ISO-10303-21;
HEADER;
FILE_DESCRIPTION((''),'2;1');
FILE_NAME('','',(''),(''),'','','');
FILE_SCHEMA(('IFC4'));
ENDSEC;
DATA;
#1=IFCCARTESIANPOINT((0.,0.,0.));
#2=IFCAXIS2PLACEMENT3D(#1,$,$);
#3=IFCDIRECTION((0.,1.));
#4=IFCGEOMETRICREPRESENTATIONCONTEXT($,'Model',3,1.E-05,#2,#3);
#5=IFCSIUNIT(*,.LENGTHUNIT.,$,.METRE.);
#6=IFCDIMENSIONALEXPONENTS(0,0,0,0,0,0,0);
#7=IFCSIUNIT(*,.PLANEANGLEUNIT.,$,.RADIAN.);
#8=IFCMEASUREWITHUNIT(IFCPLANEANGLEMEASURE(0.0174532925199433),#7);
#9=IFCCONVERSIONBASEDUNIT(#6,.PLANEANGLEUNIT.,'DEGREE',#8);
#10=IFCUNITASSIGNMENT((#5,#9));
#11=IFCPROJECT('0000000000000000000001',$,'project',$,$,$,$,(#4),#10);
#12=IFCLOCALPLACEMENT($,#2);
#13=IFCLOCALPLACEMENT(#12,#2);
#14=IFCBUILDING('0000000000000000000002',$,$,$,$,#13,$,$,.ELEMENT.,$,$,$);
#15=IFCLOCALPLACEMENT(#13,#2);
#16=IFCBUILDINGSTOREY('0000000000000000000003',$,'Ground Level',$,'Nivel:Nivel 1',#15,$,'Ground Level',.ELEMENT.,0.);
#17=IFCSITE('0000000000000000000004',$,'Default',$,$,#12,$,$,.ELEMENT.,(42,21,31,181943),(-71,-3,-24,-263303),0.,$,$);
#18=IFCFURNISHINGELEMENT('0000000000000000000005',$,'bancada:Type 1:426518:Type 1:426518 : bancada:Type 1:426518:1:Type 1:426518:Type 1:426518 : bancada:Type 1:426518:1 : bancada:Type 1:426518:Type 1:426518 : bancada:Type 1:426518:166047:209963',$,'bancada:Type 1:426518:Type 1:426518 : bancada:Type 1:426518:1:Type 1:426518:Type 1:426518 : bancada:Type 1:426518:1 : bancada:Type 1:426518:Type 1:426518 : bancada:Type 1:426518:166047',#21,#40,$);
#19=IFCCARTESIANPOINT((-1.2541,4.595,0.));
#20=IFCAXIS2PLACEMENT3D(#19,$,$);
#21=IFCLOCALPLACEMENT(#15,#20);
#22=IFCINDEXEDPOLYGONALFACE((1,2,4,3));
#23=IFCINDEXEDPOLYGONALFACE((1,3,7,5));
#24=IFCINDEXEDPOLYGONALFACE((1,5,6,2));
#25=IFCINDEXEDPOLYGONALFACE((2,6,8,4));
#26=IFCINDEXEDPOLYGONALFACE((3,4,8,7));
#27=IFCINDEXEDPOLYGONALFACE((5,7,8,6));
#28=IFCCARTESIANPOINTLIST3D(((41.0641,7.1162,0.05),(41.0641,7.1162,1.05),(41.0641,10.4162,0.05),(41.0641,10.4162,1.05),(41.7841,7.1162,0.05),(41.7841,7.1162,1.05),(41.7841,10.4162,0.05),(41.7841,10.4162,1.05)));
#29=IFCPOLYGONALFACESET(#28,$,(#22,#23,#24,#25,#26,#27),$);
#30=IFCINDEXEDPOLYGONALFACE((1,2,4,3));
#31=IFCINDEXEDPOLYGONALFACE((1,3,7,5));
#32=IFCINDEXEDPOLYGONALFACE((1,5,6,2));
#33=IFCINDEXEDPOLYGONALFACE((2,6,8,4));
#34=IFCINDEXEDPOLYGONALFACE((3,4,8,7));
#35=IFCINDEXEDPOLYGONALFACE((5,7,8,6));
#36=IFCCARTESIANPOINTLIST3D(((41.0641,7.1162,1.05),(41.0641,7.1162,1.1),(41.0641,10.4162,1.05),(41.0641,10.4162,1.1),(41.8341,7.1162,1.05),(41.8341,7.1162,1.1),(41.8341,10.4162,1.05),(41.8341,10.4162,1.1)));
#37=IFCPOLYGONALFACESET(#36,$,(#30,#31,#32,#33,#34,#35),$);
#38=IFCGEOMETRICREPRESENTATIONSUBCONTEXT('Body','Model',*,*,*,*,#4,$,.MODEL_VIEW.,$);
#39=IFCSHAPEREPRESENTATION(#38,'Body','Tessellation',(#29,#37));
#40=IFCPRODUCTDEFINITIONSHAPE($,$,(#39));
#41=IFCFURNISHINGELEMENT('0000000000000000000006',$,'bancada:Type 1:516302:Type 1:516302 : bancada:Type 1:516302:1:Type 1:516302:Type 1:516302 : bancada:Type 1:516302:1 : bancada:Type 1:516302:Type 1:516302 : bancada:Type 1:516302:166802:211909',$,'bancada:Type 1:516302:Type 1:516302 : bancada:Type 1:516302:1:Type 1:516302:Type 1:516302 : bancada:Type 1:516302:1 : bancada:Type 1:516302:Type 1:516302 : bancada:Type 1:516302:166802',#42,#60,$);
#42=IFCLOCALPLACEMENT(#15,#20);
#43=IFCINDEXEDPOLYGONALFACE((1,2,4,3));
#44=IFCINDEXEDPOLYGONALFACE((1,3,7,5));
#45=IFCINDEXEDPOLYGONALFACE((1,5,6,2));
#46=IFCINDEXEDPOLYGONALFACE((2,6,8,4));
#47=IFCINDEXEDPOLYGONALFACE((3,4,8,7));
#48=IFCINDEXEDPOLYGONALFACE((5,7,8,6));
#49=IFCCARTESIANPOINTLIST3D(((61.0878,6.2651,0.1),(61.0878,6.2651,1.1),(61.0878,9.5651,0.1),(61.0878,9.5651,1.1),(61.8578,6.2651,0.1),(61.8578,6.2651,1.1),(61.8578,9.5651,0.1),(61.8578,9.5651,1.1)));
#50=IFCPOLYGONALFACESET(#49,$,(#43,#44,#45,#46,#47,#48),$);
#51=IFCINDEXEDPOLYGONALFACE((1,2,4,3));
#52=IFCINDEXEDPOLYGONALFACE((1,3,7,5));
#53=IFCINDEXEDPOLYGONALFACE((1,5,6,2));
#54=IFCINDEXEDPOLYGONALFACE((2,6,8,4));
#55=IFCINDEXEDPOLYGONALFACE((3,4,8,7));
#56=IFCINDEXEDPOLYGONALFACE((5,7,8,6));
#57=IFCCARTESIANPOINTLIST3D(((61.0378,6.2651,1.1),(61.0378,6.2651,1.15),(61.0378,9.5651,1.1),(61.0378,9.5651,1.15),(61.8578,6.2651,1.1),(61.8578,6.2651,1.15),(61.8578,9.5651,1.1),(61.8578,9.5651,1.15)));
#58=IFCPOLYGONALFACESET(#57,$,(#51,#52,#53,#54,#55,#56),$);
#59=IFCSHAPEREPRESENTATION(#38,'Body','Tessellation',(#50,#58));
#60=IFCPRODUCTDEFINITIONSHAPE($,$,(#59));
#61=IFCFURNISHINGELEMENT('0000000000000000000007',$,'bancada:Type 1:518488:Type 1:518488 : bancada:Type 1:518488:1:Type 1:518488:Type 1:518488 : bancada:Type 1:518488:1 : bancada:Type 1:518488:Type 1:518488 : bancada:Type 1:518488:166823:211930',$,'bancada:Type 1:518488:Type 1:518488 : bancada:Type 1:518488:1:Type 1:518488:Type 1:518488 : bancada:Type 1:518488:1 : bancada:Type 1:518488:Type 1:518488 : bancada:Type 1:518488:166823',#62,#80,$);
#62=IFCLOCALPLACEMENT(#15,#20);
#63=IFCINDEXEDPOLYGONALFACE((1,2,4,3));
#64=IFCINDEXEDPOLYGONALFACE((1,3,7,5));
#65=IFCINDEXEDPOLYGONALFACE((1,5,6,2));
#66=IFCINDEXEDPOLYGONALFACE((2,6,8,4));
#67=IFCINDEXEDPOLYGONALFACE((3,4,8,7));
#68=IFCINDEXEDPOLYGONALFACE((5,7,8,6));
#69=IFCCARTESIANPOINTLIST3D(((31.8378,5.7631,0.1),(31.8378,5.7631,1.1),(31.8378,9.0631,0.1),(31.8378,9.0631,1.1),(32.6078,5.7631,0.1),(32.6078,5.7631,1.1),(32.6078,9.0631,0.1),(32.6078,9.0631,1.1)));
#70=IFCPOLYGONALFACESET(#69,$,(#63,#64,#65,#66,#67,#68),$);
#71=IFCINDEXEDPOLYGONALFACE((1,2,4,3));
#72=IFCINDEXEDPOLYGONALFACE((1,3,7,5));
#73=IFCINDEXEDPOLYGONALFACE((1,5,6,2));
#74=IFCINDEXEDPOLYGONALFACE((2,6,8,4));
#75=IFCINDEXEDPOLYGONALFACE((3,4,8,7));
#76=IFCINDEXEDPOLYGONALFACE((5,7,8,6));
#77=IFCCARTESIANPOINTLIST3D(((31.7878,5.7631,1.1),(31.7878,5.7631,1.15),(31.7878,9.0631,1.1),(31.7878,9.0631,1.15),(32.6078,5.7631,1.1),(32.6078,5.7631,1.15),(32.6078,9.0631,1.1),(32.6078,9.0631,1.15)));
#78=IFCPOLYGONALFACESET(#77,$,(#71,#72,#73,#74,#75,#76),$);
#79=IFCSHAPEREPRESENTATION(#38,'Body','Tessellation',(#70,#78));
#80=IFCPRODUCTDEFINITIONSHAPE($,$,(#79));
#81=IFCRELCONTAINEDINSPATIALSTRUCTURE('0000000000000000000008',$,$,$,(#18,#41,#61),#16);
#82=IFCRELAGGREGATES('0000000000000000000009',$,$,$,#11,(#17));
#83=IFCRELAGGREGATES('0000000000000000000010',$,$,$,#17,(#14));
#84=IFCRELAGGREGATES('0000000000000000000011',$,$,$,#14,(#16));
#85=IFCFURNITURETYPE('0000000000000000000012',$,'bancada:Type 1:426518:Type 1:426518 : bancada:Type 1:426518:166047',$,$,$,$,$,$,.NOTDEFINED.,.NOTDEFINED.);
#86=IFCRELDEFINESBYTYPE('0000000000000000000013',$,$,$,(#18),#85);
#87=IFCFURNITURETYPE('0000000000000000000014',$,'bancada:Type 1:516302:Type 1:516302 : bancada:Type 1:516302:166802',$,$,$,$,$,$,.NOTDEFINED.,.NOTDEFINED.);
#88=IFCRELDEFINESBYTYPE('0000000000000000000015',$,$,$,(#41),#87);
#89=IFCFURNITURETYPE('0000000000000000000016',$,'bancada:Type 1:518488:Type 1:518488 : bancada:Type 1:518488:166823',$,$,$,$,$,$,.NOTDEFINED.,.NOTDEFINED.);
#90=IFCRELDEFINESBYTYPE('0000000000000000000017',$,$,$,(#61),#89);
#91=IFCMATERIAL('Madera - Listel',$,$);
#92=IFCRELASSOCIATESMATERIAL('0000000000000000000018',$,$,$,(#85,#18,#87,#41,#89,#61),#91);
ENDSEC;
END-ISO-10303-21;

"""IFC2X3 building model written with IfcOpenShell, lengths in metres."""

from ifc_helpers import new_model, entity, si_unit, converted_unit, direction, frame, frame_2d, origin, origin_2d_with_axis, place, context, subcontext, project, spatial, rectangle, extrude, source, transform, mapped, material, type_object, type_shapes, element, save


model = new_model("IFC2X3")

# Units and contexts
model_context = context("Model", 3, precision=1e-05, world=origin(), true_north=direction((0.0, 1.0)))
body_context = subcontext(model_context, "Body", "Model", "MODEL_VIEW")
ifc_project = project(units=[si_unit("LENGTHUNIT", "METRE"), converted_unit("PLANEANGLEUNIT", "DEGREE", entity("IfcPlaneAngleMeasure", 0.0174532925199433), si_unit("PLANEANGLEUNIT", "RADIAN"), dimensions=[0, 0, 0, 0, 0, 0, 0])], contexts=[model_context])

# Site, building, storey
site_placement = place(None, origin())
site = spatial("IfcSite", under=ifc_project, at=site_placement, Name="Default", CompositionType="ELEMENT", RefLatitude=(42, 21, 31, 181943), RefLongitude=(-71, -3, -24, -263303), RefElevation=0.0)
building_placement = place(site_placement, origin())
building = spatial("IfcBuilding", under=site, at=building_placement, CompositionType="ELEMENT")
storey_placement = place(building_placement, origin())
storey = spatial("IfcBuildingStorey", under=building, at=storey_placement, Name="Ground Level", ObjectType="Nivel:Nivel 1", LongName="Ground Level", CompositionType="ELEMENT", Elevation=0.0)

# Furnishing elements
ifc_material_1 = material(Name="Madera - Listel")
furniture_type_1 = type_object("IfcFurnitureType", Name="bancada:Type 1:426518:Type 1:426518 : bancada:Type 1:426518:166047", AssemblyPlace="NOTDEFINED", material=ifc_material_1)
shared_shape_1 = source(origin(), body_context, "Body", "SweptSolid", [
    extrude(rectangle(XDim=0.72, YDim=3.3, at=frame_2d((0.0, 0.0), x_axis=(1.0, 0.0))), frame((41.4241, 8.7662, 0.05), z_axis=(0.0, 0.0, 1.0), x_axis=(-1.0, 0.0, 0.0)), (0.0, 0.0, 1.0), 1.0),
    extrude(rectangle(XDim=3.3, YDim=0.77, at=origin_2d_with_axis()), frame((41.4491, 8.7662, 1.05), z_axis=(0.0, 0.0, 1.0), x_axis=(0.0, -1.0, 0.0)), (0.0, 0.0, 1.0), 0.05),
])
type_shapes(furniture_type_1, [shared_shape_1])
furnishing_1_placement = place(storey_placement, frame((-1.2541, 4.595, 0.0)))
element("IfcFurnishingElement", 1, at=furnishing_1_placement, inside=storey, type_object=furniture_type_1, material=ifc_material_1, Name="bancada:Type 1:426518:Type 1:426518 : bancada:Type 1:426518:1:Type 1:426518:Type 1:426518 : bancada:Type 1:426518:1 : bancada:Type 1:426518:Type 1:426518 : bancada:Type 1:426518:166047:209963", ObjectType="bancada:Type 1:426518:Type 1:426518 : bancada:Type 1:426518:1:Type 1:426518:Type 1:426518 : bancada:Type 1:426518:1 : bancada:Type 1:426518:Type 1:426518 : bancada:Type 1:426518:166047", context=body_context, shape_type="MappedRepresentation", body=[
    mapped(shared_shape_1, transform((0.0, 0.0, 0.0), scale=1.0)),
])
furniture_type_2 = type_object("IfcFurnitureType", Name="bancada:Type 1:516302:Type 1:516302 : bancada:Type 1:516302:166802", AssemblyPlace="NOTDEFINED", material=ifc_material_1)
shared_shape_2 = source(origin(), body_context, "Body", "SweptSolid", [
    extrude(rectangle(XDim=3.3, YDim=0.77, at=origin_2d_with_axis()), frame((61.4728, 7.9151, 0.1), z_axis=(0.0, 0.0, 1.0), x_axis=(0.0, -1.0, 0.0)), (0.0, 0.0, 1.0), 1.0),
    extrude(rectangle(XDim=0.82, YDim=3.3, at=frame_2d((0.0, 0.0), x_axis=(1.0, 0.0))), frame((61.4478, 7.9151, 1.1), z_axis=(0.0, 0.0, 1.0), x_axis=(-1.0, 0.0, 0.0)), (0.0, 0.0, 1.0), 0.05),
])
type_shapes(furniture_type_2, [shared_shape_2])
furnishing_2_placement = place(storey_placement, frame((-1.2541, 4.595, 0.0)))
element("IfcFurnishingElement", 2, at=furnishing_2_placement, inside=storey, type_object=furniture_type_2, material=ifc_material_1, Name="bancada:Type 1:516302:Type 1:516302 : bancada:Type 1:516302:1:Type 1:516302:Type 1:516302 : bancada:Type 1:516302:1 : bancada:Type 1:516302:Type 1:516302 : bancada:Type 1:516302:166802:211909", ObjectType="bancada:Type 1:516302:Type 1:516302 : bancada:Type 1:516302:1:Type 1:516302:Type 1:516302 : bancada:Type 1:516302:1 : bancada:Type 1:516302:Type 1:516302 : bancada:Type 1:516302:166802", context=body_context, shape_type="MappedRepresentation", body=[
    mapped(shared_shape_2, transform((0.0, 0.0, 0.0), scale=1.0)),
])
furniture_type_3 = type_object("IfcFurnitureType", Name="bancada:Type 1:518488:Type 1:518488 : bancada:Type 1:518488:166823", AssemblyPlace="NOTDEFINED", material=ifc_material_1)
shared_shape_3 = source(origin(), body_context, "Body", "SweptSolid", [
    extrude(rectangle(XDim=3.3, YDim=0.77, at=frame_2d((0.0, 0.0), x_axis=(1.0, 0.0))), frame((32.2228, 7.4131, 0.1), z_axis=(0.0, 0.0, 1.0), x_axis=(0.0, -1.0, 0.0)), (0.0, 0.0, 1.0), 1.0),
    extrude(rectangle(XDim=0.82, YDim=3.3, at=origin_2d_with_axis()), frame((32.1978, 7.4131, 1.1), z_axis=(0.0, 0.0, 1.0), x_axis=(-1.0, 0.0, 0.0)), (0.0, 0.0, 1.0), 0.05),
])
type_shapes(furniture_type_3, [shared_shape_3])
furnishing_3_placement = place(storey_placement, frame((-1.2541, 4.595, 0.0)))
element("IfcFurnishingElement", 3, at=furnishing_3_placement, inside=storey, type_object=furniture_type_3, material=ifc_material_1, Name="bancada:Type 1:518488:Type 1:518488 : bancada:Type 1:518488:1:Type 1:518488:Type 1:518488 : bancada:Type 1:518488:1 : bancada:Type 1:518488:Type 1:518488 : bancada:Type 1:518488:166823:211930", ObjectType="bancada:Type 1:518488:Type 1:518488 : bancada:Type 1:518488:1:Type 1:518488:Type 1:518488 : bancada:Type 1:518488:1 : bancada:Type 1:518488:Type 1:518488 : bancada:Type 1:518488:166823", context=body_context, shape_type="MappedRepresentation", body=[
    mapped(shared_shape_3, transform((0.0, 0.0, 0.0), scale=1.0)),
])

save(model, "model.ifc")
